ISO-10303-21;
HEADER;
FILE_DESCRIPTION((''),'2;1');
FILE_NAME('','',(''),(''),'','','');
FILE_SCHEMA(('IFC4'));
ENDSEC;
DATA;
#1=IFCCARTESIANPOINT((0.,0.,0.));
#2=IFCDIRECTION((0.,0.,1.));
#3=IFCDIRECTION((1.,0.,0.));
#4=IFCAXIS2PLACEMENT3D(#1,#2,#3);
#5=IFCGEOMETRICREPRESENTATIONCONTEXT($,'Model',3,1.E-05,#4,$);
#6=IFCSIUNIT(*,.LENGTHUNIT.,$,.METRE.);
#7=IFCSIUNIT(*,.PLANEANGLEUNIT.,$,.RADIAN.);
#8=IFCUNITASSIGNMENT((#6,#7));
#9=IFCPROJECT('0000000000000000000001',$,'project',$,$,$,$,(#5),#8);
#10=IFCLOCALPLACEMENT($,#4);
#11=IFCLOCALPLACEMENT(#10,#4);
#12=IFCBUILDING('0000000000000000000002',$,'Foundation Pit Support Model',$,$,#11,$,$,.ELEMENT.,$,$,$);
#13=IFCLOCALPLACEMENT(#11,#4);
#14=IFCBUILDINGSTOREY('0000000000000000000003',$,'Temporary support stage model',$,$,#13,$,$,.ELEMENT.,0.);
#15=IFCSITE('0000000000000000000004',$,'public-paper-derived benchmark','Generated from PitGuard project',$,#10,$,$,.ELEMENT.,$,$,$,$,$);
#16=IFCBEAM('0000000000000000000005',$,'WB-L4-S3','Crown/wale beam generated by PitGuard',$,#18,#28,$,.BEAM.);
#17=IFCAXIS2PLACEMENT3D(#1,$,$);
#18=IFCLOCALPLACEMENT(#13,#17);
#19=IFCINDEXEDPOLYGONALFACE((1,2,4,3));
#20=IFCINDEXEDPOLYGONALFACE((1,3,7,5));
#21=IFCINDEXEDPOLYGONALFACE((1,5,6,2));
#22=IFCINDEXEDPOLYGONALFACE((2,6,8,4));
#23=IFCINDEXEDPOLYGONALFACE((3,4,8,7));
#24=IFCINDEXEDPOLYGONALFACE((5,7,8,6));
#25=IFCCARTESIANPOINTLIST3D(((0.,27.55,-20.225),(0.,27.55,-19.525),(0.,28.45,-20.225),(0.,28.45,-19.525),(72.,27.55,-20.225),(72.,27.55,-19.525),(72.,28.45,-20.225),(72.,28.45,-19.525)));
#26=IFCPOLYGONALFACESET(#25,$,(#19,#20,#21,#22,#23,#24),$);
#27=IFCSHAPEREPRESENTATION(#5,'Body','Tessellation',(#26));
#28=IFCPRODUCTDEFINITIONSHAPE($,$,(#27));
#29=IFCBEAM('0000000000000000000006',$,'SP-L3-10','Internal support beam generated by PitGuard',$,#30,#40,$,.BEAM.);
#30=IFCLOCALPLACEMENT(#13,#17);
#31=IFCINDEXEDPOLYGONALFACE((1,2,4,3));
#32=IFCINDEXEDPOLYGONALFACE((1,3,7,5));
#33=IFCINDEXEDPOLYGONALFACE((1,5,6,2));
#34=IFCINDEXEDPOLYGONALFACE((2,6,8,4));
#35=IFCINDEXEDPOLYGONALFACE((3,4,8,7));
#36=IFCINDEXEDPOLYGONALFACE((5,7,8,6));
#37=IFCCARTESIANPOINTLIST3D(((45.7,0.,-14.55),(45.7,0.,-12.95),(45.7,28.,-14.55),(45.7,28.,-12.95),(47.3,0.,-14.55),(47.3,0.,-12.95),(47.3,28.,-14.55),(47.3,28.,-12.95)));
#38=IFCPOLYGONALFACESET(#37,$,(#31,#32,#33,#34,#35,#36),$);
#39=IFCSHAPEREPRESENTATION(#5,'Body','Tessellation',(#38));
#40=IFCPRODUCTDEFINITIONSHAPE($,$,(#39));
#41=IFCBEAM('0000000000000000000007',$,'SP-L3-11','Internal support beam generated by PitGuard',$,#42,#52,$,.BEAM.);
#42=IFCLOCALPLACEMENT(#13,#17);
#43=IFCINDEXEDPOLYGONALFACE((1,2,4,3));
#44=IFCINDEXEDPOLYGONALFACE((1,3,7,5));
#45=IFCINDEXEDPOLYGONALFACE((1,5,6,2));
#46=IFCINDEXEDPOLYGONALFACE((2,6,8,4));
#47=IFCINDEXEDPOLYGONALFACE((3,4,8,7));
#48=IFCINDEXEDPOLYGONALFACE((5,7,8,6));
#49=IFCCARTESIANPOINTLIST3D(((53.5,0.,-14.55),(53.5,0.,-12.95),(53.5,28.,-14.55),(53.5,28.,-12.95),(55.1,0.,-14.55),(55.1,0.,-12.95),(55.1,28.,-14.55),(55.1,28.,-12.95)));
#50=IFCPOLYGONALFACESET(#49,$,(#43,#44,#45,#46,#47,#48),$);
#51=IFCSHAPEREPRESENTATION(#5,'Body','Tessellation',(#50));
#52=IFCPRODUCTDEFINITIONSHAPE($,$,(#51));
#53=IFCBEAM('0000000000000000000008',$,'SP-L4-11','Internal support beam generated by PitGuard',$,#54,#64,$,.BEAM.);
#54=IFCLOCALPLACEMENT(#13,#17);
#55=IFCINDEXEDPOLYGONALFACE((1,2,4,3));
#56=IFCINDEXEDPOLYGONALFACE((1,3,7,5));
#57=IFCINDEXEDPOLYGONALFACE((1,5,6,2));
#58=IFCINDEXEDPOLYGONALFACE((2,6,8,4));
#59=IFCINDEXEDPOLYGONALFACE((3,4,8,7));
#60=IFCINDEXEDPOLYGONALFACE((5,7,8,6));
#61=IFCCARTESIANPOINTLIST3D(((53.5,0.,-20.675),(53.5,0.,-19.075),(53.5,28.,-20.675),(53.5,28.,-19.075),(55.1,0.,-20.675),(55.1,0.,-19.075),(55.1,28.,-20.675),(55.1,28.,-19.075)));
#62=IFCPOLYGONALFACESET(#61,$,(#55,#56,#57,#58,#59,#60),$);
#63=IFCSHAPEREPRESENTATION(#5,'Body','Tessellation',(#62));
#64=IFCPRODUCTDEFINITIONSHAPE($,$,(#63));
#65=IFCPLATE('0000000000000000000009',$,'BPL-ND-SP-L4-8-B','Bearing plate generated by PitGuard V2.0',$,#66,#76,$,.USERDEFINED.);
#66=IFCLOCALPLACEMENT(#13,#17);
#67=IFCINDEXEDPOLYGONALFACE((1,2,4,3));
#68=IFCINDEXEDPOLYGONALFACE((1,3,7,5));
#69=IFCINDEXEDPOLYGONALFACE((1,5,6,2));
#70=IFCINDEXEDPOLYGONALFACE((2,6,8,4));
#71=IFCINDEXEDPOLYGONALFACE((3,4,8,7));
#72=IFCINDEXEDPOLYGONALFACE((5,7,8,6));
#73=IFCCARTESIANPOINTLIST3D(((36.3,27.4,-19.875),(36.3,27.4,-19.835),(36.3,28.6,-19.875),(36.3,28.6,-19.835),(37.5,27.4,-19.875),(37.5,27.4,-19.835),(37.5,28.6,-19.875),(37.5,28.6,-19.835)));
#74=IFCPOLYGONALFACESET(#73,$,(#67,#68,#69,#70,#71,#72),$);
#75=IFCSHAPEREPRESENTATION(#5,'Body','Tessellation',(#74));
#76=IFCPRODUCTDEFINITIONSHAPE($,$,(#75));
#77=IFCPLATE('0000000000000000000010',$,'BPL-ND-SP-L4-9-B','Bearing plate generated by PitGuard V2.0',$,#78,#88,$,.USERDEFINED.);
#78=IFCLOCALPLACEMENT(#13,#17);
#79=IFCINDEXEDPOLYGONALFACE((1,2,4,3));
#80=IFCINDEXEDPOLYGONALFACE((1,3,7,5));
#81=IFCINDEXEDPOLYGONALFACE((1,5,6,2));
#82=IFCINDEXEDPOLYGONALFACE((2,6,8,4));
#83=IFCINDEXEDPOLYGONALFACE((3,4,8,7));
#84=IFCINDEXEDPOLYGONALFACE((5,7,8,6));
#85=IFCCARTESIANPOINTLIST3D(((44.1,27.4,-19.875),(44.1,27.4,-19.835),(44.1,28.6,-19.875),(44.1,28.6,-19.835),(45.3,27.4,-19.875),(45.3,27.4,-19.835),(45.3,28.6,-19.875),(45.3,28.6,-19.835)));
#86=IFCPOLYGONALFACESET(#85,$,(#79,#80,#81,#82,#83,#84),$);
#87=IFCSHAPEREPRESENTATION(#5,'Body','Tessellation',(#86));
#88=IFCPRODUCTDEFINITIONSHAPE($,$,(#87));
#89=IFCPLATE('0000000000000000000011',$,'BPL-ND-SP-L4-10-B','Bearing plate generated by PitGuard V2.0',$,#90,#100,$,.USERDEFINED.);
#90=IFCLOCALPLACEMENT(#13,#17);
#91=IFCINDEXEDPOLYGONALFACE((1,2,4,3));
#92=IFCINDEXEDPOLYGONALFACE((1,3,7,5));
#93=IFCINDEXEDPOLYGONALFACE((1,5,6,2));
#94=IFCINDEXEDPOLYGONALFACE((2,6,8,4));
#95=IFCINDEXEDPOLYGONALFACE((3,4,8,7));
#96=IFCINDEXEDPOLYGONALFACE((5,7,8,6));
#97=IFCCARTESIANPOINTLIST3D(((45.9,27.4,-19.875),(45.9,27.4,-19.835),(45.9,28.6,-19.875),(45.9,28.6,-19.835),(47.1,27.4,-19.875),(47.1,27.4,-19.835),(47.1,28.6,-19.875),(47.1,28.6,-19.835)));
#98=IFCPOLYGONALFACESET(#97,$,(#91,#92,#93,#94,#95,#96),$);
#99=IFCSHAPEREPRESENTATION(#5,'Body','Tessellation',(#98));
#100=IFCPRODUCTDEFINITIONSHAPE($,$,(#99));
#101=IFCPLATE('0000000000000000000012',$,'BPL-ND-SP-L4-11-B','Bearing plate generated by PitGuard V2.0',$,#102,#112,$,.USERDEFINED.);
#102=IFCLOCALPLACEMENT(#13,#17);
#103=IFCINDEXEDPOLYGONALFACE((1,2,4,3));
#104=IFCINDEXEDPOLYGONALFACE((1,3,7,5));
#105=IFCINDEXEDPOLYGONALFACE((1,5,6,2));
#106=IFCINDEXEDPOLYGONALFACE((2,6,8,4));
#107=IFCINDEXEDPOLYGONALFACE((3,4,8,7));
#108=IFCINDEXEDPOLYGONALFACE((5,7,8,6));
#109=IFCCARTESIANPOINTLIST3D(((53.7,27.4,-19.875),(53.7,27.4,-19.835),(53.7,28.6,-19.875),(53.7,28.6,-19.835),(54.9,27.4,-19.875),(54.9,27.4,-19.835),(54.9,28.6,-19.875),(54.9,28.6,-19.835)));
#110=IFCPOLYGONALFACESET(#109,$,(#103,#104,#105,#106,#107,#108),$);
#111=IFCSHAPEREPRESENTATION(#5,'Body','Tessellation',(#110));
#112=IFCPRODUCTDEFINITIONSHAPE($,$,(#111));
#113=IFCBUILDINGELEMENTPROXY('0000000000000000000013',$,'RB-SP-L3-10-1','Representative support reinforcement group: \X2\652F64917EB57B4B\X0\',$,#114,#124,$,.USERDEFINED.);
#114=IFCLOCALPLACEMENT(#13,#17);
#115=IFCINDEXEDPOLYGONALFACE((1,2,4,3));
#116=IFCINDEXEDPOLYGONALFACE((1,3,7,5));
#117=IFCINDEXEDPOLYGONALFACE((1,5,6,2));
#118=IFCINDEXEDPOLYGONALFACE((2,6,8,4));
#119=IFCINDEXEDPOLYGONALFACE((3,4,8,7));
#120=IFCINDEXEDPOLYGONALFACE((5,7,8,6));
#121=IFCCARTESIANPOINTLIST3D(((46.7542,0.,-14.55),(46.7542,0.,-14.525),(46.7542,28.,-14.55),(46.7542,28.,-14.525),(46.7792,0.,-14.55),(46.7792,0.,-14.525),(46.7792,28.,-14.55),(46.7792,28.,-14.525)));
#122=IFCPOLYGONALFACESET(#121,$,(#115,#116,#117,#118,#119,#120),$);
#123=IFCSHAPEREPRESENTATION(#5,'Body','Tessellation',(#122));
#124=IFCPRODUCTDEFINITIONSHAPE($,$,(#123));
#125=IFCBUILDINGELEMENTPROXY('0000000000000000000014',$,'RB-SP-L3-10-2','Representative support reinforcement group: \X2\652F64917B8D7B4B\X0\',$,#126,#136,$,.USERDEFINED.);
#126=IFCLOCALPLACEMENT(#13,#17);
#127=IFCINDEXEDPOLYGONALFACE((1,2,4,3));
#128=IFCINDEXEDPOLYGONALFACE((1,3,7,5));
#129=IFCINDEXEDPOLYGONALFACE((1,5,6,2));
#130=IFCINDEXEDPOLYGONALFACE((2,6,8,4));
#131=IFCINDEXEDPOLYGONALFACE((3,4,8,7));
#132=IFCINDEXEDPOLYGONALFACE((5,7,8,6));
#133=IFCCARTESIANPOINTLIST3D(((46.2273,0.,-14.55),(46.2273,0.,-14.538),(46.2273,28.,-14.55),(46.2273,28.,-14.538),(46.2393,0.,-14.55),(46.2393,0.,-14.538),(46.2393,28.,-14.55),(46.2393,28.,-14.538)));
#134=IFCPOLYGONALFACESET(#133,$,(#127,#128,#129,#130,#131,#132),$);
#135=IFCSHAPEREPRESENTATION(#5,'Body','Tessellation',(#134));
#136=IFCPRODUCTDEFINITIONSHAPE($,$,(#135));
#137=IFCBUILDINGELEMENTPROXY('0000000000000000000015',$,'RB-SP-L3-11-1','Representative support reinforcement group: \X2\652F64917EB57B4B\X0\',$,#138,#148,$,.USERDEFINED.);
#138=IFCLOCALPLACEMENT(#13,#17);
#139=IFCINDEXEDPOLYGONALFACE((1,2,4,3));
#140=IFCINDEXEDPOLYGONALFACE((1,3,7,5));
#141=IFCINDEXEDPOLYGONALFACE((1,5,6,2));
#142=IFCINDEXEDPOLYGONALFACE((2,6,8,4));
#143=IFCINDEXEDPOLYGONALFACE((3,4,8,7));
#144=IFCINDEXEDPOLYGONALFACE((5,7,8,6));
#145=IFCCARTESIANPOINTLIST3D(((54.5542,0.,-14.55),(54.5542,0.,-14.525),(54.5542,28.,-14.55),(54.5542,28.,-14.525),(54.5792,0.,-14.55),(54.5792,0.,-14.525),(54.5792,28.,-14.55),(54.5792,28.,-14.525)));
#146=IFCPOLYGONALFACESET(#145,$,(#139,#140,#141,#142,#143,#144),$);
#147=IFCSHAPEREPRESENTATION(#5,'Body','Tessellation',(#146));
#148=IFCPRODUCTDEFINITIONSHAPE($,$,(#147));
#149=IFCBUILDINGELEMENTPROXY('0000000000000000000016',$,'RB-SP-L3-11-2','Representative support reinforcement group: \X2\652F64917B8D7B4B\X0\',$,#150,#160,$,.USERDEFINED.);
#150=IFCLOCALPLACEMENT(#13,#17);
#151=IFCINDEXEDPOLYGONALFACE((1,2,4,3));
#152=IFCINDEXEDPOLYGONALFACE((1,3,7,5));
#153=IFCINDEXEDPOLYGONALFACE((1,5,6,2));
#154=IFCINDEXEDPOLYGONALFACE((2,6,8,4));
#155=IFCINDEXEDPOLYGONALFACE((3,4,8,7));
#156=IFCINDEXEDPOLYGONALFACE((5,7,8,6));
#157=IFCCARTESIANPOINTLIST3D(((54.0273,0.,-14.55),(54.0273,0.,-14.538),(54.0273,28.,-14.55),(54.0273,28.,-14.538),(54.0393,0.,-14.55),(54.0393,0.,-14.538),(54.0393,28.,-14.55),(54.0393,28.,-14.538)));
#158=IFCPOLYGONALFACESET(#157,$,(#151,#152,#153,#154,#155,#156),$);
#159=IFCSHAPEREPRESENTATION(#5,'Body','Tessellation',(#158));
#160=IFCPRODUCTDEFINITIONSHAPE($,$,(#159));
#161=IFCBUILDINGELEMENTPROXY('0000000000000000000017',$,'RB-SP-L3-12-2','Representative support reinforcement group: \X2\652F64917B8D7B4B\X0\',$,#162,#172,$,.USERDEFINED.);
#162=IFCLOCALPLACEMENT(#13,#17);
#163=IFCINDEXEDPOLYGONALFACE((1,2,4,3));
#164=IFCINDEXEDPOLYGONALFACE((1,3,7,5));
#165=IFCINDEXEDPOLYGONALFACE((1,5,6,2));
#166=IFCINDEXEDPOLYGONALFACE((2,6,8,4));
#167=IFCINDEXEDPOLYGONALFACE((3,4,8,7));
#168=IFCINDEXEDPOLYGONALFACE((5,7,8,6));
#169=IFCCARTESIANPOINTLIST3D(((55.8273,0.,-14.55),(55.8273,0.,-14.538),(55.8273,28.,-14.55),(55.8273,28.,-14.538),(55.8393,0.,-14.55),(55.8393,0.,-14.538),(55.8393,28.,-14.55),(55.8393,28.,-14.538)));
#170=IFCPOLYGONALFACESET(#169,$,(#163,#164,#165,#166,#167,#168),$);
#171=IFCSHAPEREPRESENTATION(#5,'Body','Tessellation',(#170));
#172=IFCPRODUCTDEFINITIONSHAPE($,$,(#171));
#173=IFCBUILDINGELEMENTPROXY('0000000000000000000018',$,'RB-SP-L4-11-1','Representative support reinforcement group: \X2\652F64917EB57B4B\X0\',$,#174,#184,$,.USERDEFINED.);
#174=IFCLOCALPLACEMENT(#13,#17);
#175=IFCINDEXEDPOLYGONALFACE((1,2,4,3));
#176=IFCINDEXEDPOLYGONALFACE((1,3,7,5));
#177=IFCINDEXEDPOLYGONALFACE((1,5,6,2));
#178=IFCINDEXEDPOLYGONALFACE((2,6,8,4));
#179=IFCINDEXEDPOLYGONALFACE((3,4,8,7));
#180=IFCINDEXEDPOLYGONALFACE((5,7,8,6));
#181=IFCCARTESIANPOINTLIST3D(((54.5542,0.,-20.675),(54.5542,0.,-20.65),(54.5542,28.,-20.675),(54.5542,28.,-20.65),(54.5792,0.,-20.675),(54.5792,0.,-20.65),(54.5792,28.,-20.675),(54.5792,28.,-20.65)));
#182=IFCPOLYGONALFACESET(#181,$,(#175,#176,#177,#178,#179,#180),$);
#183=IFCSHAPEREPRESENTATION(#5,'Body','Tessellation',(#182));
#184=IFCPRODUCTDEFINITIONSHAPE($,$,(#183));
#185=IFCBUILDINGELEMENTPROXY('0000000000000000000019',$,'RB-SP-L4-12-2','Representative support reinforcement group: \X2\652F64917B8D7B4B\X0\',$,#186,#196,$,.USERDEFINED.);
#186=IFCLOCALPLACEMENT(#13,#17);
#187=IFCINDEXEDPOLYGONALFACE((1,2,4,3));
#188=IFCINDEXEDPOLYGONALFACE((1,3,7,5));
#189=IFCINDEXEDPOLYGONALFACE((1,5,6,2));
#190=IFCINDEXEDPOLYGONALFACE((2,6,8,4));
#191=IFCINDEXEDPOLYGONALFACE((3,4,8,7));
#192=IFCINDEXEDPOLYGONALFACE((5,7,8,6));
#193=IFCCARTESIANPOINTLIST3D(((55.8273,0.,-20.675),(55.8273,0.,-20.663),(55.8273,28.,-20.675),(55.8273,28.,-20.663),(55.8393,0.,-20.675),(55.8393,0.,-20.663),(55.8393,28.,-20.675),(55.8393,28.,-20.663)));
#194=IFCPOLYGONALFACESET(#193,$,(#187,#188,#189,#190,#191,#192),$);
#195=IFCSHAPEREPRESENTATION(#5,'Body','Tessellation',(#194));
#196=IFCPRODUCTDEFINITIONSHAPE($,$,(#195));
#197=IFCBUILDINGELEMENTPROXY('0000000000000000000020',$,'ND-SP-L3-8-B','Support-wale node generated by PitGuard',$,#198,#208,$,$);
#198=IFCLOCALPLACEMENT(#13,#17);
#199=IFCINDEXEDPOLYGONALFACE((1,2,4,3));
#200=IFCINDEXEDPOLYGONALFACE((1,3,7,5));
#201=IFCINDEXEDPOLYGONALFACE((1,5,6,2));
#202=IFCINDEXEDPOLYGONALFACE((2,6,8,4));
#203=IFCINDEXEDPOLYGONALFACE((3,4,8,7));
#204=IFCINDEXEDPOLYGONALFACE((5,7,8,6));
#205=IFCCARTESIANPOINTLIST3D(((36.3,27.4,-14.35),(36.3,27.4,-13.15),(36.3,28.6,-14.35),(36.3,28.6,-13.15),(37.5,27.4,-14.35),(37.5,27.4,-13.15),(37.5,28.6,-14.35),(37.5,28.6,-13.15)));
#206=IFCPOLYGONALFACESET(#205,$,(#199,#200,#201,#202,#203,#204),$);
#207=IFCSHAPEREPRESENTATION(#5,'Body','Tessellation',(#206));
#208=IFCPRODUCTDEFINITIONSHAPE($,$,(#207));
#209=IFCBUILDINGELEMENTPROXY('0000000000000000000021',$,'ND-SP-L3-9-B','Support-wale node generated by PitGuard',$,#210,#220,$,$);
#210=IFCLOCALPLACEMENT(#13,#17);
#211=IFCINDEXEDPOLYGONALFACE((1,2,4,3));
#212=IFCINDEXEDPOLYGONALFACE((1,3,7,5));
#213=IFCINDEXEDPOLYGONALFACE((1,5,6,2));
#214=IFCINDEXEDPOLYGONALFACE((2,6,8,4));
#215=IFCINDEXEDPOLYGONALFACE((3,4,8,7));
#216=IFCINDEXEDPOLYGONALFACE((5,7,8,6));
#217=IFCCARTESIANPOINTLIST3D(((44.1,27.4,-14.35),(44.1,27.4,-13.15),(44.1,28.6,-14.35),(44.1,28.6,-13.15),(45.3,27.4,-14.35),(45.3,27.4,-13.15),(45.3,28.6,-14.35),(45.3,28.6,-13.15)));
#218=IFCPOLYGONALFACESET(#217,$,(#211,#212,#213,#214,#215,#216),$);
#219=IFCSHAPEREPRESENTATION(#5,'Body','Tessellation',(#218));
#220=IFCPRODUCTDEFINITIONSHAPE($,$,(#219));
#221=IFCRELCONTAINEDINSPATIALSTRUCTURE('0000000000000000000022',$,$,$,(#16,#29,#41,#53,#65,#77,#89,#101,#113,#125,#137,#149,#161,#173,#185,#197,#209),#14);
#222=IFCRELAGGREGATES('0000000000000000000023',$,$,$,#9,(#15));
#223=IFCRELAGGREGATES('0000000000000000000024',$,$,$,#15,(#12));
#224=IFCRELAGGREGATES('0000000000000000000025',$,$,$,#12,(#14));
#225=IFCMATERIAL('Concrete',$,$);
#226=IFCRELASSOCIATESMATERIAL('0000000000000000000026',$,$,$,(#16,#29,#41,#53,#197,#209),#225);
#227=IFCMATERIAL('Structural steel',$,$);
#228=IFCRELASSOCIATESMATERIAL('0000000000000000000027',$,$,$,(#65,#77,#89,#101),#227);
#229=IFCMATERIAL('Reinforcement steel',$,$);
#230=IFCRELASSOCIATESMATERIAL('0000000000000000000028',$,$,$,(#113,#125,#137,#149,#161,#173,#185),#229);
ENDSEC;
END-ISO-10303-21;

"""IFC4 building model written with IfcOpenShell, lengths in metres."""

from ifc_helpers import new_model, si_unit, frame, origin_with_axes, origin_2d, place, context, project, spatial, rectangle, extrude, material, element, save


model = new_model("IFC4")

# Units and contexts
model_context = context("Model", 3, precision=1e-05, world=origin_with_axes())
ifc_project = project(units=[si_unit("LENGTHUNIT", "METRE"), si_unit("PLANEANGLEUNIT", "RADIAN")], contexts=[model_context])

# Site, building, storey
site_placement = place(None, origin_with_axes())
site = spatial("IfcSite", under=ifc_project, at=site_placement, Name="public-paper-derived benchmark", Description="Generated from PitGuard project", CompositionType="ELEMENT")
building_placement = place(site_placement, origin_with_axes())
building = spatial("IfcBuilding", under=site, at=building_placement, Name="Foundation Pit Support Model", CompositionType="ELEMENT")
storey_placement = place(building_placement, origin_with_axes())
storey = spatial("IfcBuildingStorey", under=building, at=storey_placement, Name="Temporary support stage model", CompositionType="ELEMENT", Elevation=0.0)

# Beams
ifc_material_1 = material(Name="Concrete")
beam_placement = place(storey_placement, frame((36.0, 28.0, -20.225), z_axis=(0.0, 0.0, 1.0), x_axis=(-1.0, 0.0, 0.0)))
element("IfcBeam", 1, at=beam_placement, inside=storey, material=ifc_material_1, Name="WB-L4-S3", Description="Crown/wale beam generated by PitGuard", PredefinedType="BEAM", context=model_context, shape_type="SweptSolid", body=[
    extrude(rectangle(XDim=72.0, YDim=0.9, at=origin_2d()), origin_with_axes(), (0.0, 0.0, 1.0), 0.7),
])
for number, where, z_axis, x_axis, name in (
    (2, (46.5, 14.0, -14.55), (0.0, 0.0, 1.0), (0.0, 1.0, 0.0), "SP-L3-10"),
    (3, (54.3, 14.0, -14.55), (0.0, 0.0, 1.0), (0.0, 1.0, 0.0), "SP-L3-11"),
    (4, (54.3, 14.0, -20.675), (0.0, 0.0, 1.0), (0.0, 1.0, 0.0), "SP-L4-11"),
):
    element("IfcBeam", number, at=place(storey_placement, frame(where, z_axis=z_axis, x_axis=x_axis)), inside=storey, material=ifc_material_1, Name=name, Description="Internal support beam generated by PitGuard", PredefinedType="BEAM", context=model_context, shape_type="SweptSolid", body=[
        extrude(rectangle(XDim=28.0, YDim=1.6, at=origin_2d()), origin_with_axes(), (0.0, 0.0, 1.0), 1.6),
    ])

# Plates
ifc_material_2 = material(Name="Structural steel")
for number, where, z_axis, x_axis, name in (
    (5, (36.9, 28.0, -19.875), (0.0, 0.0, 1.0), (1.0, 0.0, 0.0), "BPL-ND-SP-L4-8-B"),
    (6, (44.7, 28.0, -19.875), (0.0, 0.0, 1.0), (1.0, 0.0, 0.0), "BPL-ND-SP-L4-9-B"),
    (7, (46.5, 28.0, -19.875), (0.0, 0.0, 1.0), (1.0, 0.0, 0.0), "BPL-ND-SP-L4-10-B"),
    (8, (54.3, 28.0, -19.875), (0.0, 0.0, 1.0), (1.0, 0.0, 0.0), "BPL-ND-SP-L4-11-B"),
):
    element("IfcPlate", number, at=place(storey_placement, frame(where, z_axis=z_axis, x_axis=x_axis)), inside=storey, material=ifc_material_2, Name=name, Description="Bearing plate generated by PitGuard V2.0", PredefinedType="USERDEFINED", context=model_context, shape_type="SweptSolid", body=[
        extrude(rectangle(XDim=1.2, YDim=1.2, at=origin_2d()), origin_with_axes(), (0.0, 0.0, 1.0), 0.04),
    ])

# Building element proxies
ifc_material_3 = material(Name="Reinforcement steel")
proxy_1_placement = place(storey_placement, frame((46.7667, 14.0, -14.55), z_axis=(0.0, 0.0, 1.0), x_axis=(0.0, 1.0, 0.0)))
element("IfcBuildingElementProxy", 9, at=proxy_1_placement, inside=storey, material=ifc_material_3, Name="RB-SP-L3-10-1", Description="Representative support reinforcement group: 支撑纵筋", PredefinedType="USERDEFINED", context=model_context, shape_type="SweptSolid", body=[
    extrude(rectangle(XDim=28.0, YDim=0.025, at=origin_2d()), origin_with_axes(), (0.0, 0.0, 1.0), 0.025),
])
proxy_2_placement = place(storey_placement, frame((46.2333, 14.0, -14.55), z_axis=(0.0, 0.0, 1.0), x_axis=(0.0, 1.0, 0.0)))
element("IfcBuildingElementProxy", 10, at=proxy_2_placement, inside=storey, material=ifc_material_3, Name="RB-SP-L3-10-2", Description="Representative support reinforcement group: 支撑箍筋", PredefinedType="USERDEFINED", context=model_context, shape_type="SweptSolid", body=[
    extrude(rectangle(XDim=28.0, YDim=0.012, at=origin_2d()), origin_with_axes(), (0.0, 0.0, 1.0), 0.012),
])
proxy_3_placement = place(storey_placement, frame((54.5667, 14.0, -14.55), z_axis=(0.0, 0.0, 1.0), x_axis=(0.0, 1.0, 0.0)))
element("IfcBuildingElementProxy", 11, at=proxy_3_placement, inside=storey, material=ifc_material_3, Name="RB-SP-L3-11-1", Description="Representative support reinforcement group: 支撑纵筋", PredefinedType="USERDEFINED", context=model_context, shape_type="SweptSolid", body=[
    extrude(rectangle(XDim=28.0, YDim=0.025, at=origin_2d()), origin_with_axes(), (0.0, 0.0, 1.0), 0.025),
])
for number, where, z_axis, x_axis, name in (
    (12, (54.0333, 14.0, -14.55), (0.0, 0.0, 1.0), (0.0, 1.0, 0.0), "RB-SP-L3-11-2"),
    (13, (55.8333, 14.0, -14.55), (0.0, 0.0, 1.0), (0.0, 1.0, 0.0), "RB-SP-L3-12-2"),
):
    element("IfcBuildingElementProxy", number, at=place(storey_placement, frame(where, z_axis=z_axis, x_axis=x_axis)), inside=storey, material=ifc_material_3, Name=name, Description="Representative support reinforcement group: 支撑箍筋", PredefinedType="USERDEFINED", context=model_context, shape_type="SweptSolid", body=[
        extrude(rectangle(XDim=28.0, YDim=0.012, at=origin_2d()), origin_with_axes(), (0.0, 0.0, 1.0), 0.012),
    ])
proxy_4_placement = place(storey_placement, frame((54.5667, 14.0, -20.675), z_axis=(0.0, 0.0, 1.0), x_axis=(0.0, 1.0, 0.0)))
element("IfcBuildingElementProxy", 14, at=proxy_4_placement, inside=storey, material=ifc_material_3, Name="RB-SP-L4-11-1", Description="Representative support reinforcement group: 支撑纵筋", PredefinedType="USERDEFINED", context=model_context, shape_type="SweptSolid", body=[
    extrude(rectangle(XDim=28.0, YDim=0.025, at=origin_2d()), origin_with_axes(), (0.0, 0.0, 1.0), 0.025),
])
proxy_5_placement = place(storey_placement, frame((55.8333, 14.0, -20.675), z_axis=(0.0, 0.0, 1.0), x_axis=(0.0, 1.0, 0.0)))
element("IfcBuildingElementProxy", 15, at=proxy_5_placement, inside=storey, material=ifc_material_3, Name="RB-SP-L4-12-2", Description="Representative support reinforcement group: 支撑箍筋", PredefinedType="USERDEFINED", context=model_context, shape_type="SweptSolid", body=[
    extrude(rectangle(XDim=28.0, YDim=0.012, at=origin_2d()), origin_with_axes(), (0.0, 0.0, 1.0), 0.012),
])
for number, where, z_axis, x_axis, name in (
    (16, (36.9, 28.0, -14.35), (0.0, 0.0, 1.0), (1.0, 0.0, 0.0), "ND-SP-L3-8-B"),
    (17, (44.7, 28.0, -14.35), (0.0, 0.0, 1.0), (1.0, 0.0, 0.0), "ND-SP-L3-9-B"),
):
    element("IfcBuildingElementProxy", number, at=place(storey_placement, frame(where, z_axis=z_axis, x_axis=x_axis)), inside=storey, material=ifc_material_1, Name=name, Description="Support-wale node generated by PitGuard", context=model_context, shape_type="SweptSolid", body=[
        extrude(rectangle(XDim=1.2, YDim=1.2, at=origin_2d()), origin_with_axes(), (0.0, 0.0, 1.0), 1.2),
    ])

save(model, "model.ifc")
